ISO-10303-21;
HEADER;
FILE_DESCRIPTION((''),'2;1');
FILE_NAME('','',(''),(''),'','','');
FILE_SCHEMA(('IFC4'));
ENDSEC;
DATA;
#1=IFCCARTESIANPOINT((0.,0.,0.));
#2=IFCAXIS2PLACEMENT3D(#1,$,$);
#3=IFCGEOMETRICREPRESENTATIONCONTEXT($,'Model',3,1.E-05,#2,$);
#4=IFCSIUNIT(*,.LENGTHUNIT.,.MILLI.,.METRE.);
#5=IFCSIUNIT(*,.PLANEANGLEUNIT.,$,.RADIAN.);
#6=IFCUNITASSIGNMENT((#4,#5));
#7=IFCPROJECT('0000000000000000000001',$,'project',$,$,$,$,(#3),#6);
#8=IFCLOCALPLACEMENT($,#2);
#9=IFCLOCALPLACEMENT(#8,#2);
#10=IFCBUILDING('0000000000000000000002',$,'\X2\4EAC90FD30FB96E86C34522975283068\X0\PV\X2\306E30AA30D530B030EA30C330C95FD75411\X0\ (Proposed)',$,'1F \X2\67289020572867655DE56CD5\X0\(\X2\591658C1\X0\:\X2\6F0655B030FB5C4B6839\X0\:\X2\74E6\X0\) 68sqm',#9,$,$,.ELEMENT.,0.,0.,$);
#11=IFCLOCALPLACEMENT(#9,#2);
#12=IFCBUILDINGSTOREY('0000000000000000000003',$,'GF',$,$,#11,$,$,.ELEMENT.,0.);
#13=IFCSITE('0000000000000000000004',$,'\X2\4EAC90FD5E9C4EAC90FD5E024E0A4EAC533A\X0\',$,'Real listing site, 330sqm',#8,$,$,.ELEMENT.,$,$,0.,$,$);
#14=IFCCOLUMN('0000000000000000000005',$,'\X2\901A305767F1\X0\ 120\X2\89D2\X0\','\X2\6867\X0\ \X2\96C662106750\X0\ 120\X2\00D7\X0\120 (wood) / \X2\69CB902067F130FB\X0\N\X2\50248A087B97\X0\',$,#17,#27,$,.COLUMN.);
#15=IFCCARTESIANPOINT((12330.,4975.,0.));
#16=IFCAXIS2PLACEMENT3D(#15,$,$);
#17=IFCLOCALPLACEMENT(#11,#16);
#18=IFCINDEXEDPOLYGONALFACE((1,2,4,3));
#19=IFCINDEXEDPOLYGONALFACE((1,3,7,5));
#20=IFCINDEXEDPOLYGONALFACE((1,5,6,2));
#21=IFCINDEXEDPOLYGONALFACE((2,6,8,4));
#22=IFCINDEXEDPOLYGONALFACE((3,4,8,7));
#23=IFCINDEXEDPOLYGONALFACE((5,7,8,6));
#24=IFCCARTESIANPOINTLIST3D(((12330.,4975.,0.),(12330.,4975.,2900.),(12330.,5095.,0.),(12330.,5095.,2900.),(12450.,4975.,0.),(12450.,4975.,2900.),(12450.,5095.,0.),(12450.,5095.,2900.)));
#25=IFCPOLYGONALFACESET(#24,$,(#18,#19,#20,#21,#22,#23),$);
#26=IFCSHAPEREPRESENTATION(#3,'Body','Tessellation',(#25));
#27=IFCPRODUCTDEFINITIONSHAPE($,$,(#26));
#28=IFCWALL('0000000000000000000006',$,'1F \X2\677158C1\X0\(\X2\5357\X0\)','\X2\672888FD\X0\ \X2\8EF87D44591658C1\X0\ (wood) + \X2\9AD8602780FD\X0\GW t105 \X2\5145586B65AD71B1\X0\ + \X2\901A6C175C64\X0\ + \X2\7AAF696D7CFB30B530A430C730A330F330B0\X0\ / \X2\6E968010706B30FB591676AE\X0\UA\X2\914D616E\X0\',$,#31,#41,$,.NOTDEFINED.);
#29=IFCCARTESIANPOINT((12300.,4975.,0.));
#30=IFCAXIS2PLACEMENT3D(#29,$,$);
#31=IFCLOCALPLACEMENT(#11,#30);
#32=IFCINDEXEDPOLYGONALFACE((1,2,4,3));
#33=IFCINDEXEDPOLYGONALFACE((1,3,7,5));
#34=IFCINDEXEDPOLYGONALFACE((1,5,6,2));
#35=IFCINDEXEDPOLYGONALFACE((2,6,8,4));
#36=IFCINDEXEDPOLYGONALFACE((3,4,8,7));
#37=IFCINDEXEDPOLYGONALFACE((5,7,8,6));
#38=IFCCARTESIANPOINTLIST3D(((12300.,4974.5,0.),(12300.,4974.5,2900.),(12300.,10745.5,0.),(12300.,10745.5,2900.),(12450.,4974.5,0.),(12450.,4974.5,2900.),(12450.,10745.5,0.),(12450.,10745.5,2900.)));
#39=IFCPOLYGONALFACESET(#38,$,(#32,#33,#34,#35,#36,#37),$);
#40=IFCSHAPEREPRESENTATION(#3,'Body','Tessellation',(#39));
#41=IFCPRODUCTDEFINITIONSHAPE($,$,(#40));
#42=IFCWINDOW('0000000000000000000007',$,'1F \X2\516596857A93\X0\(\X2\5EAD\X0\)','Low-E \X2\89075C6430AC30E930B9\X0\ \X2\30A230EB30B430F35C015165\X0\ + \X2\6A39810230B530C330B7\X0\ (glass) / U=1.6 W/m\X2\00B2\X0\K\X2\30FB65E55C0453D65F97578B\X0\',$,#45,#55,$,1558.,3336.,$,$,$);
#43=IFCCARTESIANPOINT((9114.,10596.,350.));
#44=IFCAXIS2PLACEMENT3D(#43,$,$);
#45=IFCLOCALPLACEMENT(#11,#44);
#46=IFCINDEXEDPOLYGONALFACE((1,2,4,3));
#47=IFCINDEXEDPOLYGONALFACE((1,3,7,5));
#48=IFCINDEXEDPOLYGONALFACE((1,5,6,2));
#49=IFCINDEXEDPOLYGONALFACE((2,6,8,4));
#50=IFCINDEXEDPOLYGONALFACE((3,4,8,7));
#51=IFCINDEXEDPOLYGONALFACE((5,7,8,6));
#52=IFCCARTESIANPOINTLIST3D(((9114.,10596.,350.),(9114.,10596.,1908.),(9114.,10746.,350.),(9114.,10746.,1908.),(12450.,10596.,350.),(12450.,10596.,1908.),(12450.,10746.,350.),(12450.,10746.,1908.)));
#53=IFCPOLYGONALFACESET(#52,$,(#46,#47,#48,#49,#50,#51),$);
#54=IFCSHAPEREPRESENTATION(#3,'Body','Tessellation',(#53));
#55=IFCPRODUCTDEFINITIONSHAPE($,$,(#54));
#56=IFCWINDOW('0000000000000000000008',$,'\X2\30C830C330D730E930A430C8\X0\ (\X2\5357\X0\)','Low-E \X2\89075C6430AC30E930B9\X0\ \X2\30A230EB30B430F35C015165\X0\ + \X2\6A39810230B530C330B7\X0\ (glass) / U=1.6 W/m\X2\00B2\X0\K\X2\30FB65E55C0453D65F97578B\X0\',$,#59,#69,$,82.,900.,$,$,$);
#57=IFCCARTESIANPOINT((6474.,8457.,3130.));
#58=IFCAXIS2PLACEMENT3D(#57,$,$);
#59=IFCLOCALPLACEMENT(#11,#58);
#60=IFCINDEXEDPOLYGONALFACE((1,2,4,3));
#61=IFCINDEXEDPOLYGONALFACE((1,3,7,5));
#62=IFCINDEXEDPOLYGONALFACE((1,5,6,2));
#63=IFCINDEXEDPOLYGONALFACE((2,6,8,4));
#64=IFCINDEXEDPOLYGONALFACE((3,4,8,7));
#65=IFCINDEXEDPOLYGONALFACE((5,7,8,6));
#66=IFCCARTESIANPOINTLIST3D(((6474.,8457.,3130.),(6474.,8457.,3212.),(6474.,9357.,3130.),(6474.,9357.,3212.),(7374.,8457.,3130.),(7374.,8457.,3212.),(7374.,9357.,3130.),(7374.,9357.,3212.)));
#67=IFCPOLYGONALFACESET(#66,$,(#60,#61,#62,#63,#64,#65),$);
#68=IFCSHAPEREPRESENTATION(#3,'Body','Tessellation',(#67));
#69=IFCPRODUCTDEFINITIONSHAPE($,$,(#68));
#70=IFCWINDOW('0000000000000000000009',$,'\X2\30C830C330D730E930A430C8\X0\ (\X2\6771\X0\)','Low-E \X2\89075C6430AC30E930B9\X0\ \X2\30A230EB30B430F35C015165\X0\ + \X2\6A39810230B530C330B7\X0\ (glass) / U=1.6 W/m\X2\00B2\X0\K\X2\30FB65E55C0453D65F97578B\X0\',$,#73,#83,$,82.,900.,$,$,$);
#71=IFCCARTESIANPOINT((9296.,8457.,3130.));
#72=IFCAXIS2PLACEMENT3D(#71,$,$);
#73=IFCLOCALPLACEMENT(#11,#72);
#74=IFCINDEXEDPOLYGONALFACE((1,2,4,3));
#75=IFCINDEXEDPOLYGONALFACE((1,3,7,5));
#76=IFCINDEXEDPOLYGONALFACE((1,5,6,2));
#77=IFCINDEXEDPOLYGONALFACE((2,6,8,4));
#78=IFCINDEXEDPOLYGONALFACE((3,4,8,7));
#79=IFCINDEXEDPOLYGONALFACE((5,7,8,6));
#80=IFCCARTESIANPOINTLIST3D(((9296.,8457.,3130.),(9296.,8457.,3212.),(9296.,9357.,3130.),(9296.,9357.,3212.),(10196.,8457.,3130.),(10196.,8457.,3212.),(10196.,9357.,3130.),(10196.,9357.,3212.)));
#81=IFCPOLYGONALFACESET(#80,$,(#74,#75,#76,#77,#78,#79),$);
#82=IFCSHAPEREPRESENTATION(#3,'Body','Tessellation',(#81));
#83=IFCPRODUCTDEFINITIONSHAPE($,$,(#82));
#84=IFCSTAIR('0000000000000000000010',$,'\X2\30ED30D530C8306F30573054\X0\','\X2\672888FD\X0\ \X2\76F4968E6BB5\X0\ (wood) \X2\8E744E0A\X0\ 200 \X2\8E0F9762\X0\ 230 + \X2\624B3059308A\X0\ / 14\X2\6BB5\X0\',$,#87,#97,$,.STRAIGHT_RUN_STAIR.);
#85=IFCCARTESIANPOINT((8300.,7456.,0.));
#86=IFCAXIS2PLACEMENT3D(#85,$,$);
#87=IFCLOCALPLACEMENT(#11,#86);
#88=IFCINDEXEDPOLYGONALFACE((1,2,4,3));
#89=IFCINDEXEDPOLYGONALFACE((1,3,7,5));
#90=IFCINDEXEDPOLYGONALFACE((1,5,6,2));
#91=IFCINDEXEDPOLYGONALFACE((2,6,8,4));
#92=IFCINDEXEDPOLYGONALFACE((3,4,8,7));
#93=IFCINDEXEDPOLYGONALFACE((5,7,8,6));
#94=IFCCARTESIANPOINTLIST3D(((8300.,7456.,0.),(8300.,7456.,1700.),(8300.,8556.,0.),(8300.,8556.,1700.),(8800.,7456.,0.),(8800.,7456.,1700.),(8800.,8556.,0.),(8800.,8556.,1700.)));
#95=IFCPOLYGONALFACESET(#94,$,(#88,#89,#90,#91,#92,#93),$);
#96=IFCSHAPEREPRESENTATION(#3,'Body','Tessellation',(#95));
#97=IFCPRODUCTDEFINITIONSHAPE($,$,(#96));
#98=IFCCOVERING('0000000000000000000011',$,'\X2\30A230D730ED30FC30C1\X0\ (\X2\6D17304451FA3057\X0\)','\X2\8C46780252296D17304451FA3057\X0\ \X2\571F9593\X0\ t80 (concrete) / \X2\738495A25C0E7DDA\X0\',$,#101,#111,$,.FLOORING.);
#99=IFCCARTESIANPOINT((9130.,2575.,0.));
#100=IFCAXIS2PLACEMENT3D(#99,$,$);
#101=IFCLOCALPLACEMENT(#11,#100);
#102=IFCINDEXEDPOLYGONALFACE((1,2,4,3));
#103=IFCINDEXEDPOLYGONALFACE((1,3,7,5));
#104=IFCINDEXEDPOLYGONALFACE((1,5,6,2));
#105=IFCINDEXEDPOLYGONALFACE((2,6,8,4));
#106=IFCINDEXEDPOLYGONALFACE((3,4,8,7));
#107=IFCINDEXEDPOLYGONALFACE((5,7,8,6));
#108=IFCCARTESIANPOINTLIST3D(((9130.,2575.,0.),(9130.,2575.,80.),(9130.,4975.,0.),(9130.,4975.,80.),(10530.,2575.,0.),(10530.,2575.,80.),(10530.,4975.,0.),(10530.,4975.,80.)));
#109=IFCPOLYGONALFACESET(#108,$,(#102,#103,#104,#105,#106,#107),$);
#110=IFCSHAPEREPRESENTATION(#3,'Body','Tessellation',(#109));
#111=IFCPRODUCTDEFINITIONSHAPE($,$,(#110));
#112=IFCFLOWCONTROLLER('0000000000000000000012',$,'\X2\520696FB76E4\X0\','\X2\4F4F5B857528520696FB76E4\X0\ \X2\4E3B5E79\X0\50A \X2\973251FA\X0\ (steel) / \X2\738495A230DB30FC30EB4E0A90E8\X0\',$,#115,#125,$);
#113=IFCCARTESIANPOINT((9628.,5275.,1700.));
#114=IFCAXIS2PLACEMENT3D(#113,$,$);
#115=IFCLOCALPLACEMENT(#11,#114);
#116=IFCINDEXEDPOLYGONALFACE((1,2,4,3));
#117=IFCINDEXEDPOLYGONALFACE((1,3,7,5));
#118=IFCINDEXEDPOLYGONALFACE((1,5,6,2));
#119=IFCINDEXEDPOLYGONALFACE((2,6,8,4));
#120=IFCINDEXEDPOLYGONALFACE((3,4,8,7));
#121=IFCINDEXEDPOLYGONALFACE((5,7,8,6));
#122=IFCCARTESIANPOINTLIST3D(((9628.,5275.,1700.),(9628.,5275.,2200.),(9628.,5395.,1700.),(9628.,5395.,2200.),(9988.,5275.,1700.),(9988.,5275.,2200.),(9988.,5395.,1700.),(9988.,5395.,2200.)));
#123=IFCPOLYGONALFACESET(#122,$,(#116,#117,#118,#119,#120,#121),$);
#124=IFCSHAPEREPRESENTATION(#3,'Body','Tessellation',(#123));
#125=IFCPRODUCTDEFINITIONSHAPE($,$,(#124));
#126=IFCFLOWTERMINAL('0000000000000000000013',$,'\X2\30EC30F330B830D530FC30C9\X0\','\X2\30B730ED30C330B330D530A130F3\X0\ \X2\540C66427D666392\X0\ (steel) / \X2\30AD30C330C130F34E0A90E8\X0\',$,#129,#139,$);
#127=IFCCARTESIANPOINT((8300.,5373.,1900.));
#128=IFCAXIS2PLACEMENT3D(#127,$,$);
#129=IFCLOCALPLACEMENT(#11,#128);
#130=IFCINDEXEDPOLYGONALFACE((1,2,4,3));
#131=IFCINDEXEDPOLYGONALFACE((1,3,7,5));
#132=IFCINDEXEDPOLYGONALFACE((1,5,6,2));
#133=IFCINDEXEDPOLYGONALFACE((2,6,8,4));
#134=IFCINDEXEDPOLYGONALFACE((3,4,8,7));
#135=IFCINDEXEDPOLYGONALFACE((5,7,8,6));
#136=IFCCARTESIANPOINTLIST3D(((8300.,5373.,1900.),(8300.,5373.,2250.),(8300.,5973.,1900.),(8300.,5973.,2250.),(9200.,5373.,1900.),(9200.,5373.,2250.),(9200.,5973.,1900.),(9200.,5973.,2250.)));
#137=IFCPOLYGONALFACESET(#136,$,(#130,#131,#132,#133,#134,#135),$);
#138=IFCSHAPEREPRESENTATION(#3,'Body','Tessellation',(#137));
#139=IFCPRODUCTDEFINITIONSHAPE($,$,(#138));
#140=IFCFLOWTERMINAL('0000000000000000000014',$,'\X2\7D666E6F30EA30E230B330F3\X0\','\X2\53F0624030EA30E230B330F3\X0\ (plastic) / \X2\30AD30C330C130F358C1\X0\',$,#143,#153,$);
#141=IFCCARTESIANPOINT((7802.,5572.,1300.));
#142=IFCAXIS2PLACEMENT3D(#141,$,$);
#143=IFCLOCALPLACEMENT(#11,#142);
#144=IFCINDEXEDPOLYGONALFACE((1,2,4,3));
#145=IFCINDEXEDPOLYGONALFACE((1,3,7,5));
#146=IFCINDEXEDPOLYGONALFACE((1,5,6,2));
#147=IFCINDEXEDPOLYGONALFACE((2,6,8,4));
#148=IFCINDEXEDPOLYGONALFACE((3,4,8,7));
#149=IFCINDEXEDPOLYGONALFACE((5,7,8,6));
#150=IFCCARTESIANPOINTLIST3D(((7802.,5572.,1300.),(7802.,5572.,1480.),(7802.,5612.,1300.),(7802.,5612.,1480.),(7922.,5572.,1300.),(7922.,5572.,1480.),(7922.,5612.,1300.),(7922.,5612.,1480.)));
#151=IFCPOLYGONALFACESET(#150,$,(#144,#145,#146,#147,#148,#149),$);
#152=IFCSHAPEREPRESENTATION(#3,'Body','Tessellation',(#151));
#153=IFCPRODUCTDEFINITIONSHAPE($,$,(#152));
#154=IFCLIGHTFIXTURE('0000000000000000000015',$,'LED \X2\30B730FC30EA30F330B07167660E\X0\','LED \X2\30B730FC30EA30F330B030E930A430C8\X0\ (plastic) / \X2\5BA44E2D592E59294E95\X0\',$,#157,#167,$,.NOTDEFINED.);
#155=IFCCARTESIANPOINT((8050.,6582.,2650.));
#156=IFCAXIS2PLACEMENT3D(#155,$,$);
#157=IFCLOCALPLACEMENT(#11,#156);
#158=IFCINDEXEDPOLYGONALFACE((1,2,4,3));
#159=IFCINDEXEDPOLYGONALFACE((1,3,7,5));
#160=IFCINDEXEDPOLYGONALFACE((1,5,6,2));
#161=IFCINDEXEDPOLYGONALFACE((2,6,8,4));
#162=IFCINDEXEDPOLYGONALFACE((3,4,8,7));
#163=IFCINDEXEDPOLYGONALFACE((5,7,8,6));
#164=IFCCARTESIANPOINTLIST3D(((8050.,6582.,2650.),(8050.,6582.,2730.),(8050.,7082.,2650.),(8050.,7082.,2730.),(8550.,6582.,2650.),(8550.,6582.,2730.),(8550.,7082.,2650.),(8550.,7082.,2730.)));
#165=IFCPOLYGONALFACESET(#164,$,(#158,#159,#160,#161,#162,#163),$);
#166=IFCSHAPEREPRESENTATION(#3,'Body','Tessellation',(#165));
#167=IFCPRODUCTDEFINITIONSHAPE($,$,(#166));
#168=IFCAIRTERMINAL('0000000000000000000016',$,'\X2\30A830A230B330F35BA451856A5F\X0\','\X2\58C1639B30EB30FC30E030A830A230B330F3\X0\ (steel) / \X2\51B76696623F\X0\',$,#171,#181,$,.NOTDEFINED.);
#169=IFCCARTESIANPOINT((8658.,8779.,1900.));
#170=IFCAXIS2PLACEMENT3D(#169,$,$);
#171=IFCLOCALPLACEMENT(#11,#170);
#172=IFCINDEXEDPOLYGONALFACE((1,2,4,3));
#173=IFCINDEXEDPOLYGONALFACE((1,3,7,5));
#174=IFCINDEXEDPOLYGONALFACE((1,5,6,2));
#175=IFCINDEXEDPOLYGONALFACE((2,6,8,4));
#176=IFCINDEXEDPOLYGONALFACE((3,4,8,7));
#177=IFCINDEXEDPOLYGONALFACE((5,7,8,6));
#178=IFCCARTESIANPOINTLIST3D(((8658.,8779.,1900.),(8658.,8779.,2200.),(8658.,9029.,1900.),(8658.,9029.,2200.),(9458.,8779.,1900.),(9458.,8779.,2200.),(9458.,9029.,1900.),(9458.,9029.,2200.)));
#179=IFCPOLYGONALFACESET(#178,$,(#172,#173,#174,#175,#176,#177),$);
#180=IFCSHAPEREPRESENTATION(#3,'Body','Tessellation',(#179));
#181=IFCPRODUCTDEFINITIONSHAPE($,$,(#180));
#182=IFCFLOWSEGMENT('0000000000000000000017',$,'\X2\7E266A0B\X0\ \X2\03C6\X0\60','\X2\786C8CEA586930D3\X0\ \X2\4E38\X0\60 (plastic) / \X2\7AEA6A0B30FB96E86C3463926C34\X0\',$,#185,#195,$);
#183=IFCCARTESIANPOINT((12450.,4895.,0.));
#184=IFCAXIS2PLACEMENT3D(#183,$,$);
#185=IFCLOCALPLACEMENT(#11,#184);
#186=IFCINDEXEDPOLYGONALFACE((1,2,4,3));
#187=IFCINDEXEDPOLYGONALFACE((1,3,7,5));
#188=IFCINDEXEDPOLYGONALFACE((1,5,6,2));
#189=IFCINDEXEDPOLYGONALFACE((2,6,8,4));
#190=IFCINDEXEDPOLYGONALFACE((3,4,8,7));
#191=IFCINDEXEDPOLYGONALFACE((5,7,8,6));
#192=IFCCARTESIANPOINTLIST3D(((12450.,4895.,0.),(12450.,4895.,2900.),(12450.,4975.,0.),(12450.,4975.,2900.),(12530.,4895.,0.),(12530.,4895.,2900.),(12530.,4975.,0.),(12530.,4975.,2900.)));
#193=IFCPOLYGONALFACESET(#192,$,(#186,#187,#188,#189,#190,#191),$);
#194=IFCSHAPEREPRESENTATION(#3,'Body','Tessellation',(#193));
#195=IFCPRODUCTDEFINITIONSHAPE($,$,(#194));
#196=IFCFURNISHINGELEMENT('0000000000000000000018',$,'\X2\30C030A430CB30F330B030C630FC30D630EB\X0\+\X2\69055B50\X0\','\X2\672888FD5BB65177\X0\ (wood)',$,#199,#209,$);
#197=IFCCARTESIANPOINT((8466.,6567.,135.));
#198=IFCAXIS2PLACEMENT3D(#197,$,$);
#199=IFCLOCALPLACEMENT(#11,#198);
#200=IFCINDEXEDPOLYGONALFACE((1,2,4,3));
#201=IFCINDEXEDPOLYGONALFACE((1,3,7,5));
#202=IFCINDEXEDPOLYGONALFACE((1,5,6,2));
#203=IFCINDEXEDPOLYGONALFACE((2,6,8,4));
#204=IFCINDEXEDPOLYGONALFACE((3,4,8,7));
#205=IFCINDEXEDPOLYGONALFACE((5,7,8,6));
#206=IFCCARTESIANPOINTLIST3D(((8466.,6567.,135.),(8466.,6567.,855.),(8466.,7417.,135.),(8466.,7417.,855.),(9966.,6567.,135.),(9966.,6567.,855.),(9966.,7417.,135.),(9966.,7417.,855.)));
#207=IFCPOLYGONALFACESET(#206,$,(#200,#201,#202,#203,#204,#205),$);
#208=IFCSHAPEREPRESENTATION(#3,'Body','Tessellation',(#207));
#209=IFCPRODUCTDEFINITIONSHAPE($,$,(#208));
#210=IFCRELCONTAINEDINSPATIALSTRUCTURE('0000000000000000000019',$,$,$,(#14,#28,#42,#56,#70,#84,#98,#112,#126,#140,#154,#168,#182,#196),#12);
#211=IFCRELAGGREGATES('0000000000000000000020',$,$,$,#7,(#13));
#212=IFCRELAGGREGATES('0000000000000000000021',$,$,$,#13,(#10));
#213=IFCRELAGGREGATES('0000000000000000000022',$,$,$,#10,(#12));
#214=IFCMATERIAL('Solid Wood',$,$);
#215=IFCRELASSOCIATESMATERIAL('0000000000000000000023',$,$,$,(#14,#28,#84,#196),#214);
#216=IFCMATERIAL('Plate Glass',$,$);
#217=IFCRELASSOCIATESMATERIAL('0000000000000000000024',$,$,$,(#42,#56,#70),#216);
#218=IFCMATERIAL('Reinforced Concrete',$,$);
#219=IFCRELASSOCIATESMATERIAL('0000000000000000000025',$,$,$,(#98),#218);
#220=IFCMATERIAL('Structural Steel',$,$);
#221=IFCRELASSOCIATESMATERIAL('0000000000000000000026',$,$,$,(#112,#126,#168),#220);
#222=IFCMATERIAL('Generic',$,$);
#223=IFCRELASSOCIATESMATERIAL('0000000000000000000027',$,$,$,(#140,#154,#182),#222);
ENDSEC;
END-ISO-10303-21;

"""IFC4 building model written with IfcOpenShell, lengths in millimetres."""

from ifc_helpers import new_model, si_unit, frame, frame_2d, origin, place, context, project, spatial, rectangle, extrude, material, element, fill, save


model = new_model("IFC4")

# Units and contexts
model_context = context("Model", 3, precision=1e-05, world=origin())
ifc_project = project(units=[si_unit("LENGTHUNIT", "METRE", prefix="MILLI"), si_unit("PLANEANGLEUNIT", "RADIAN")], contexts=[model_context])

# Site, building, storey
site_placement = place(None, origin())
site = spatial("IfcSite", under=ifc_project, at=site_placement, Name="京都府京都市上京区", ObjectType="Real listing site, 330sqm", CompositionType="ELEMENT", RefElevation=0.0)
building_placement = place(site_placement, origin())
building = spatial("IfcBuilding", under=site, at=building_placement, Name="京都・雨水利用とPVのオフグリッド志向 (Proposed)", ObjectType="1F 木造在来工法(外壁:漆喰・屋根:瓦) 68sqm", CompositionType="ELEMENT", ElevationOfRefHeight=0.0, ElevationOfTerrain=0.0)
storey_placement = place(building_placement, origin())
storey = spatial("IfcBuildingStorey", under=building, at=storey_placement, Name="GF", CompositionType="ELEMENT", Elevation=0.0)

# Column
ifc_material_1 = material(Name="Solid Wood")
column_1_placement = place(storey_placement, frame((12330.0, 4975.0, 0.0)))
element("IfcColumn", 1, at=column_1_placement, inside=storey, material=ifc_material_1, Name="通し柱 120角", Description="桧 集成材 120×120 (wood) / 構造柱・N値計算", PredefinedType="COLUMN", context=model_context, shape_type="SweptSolid", body=[
    extrude(rectangle(XDim=120.0, YDim=120.0, at=frame_2d((60.0, 60.0))), frame((12330.0, 4975.0, 0.0)), (0.0, 0.0, 1.0), 2900.0),
])

# Wall, opening, window
wall_1_placement = place(storey_placement, frame((12300.0, 4975.0, 0.0)))
wall_1 = element("IfcWall", 2, at=wall_1_placement, inside=storey, material=ifc_material_1, Name="1F 東壁(南)", Description="木製 軸組外壁 (wood) + 高性能GW t105 充填断熱 + 通気層 + 窯業系サイディング / 準耐火・外皮UA配慮", PredefinedType="NOTDEFINED", context=model_context, shape_type="SweptSolid", body=[
    extrude(rectangle(XDim=150.0, YDim=5771.0, at=frame_2d((75.0, 2885.0))), frame((12300.0, 4975.0, 0.0)), (0.0, 0.0, 1.0), 2900.0),
])
opening_1_placement = place(storey_placement, frame((9114.0, 10596.0, 350.0)))
opening_1 = element("IfcOpeningElement", 3, at=opening_1_placement, cuts=wall_1, PredefinedType="NOTDEFINED", context=model_context, shape_type="SweptSolid", body=[
    extrude(rectangle(XDim=3336.0, YDim=150.0, at=frame_2d((1668.0, 75.0))), frame((9114.0, 10596.0, 350.0)), (0.0, 0.0, 1.0), 1558.0),
])
ifc_material_2 = material(Name="Plate Glass")
window_1_placement = place(storey_placement, frame((9114.0, 10596.0, 350.0)))
window_1 = element("IfcWindow", 4, at=window_1_placement, inside=storey, material=ifc_material_2, Name="1F 入隅窓(庭)", Description="Low-E 複層ガラス アルゴン封入 + 樹脂サッシ (glass) / U=1.6 W/m²K・日射取得型", OverallHeight=1558.0, OverallWidth=3336.0, context=model_context, shape_type="SweptSolid", body=[
    extrude(rectangle(XDim=3336.0, YDim=150.0, at=frame_2d((1668.0, 75.0))), frame((9114.0, 10596.0, 350.0)), (0.0, 0.0, 1.0), 1558.0),
])
fill(opening_1, window_1)

# Windows
window_2_placement = place(storey_placement, frame((6474.0, 8457.0, 3130.0)))
element("IfcWindow", 5, at=window_2_placement, inside=storey, material=ifc_material_2, Name="トップライト (南)", Description="Low-E 複層ガラス アルゴン封入 + 樹脂サッシ (glass) / U=1.6 W/m²K・日射取得型", OverallHeight=82.0, OverallWidth=900.0, context=model_context, shape_type="SweptSolid", body=[
    extrude(rectangle(XDim=900.0, YDim=900.0, at=frame_2d((450.0, 450.0))), frame((6474.0, 8457.0, 3130.0)), (0.0, 0.0, 1.0), 82.0),
])
window_3_placement = place(storey_placement, frame((9296.0, 8457.0, 3130.0)))
element("IfcWindow", 6, at=window_3_placement, inside=storey, material=ifc_material_2, Name="トップライト (東)", Description="Low-E 複層ガラス アルゴン封入 + 樹脂サッシ (glass) / U=1.6 W/m²K・日射取得型", OverallHeight=82.0, OverallWidth=900.0, context=model_context, shape_type="SweptSolid", body=[
    extrude(rectangle(XDim=900.0, YDim=900.0, at=frame_2d((450.0, 450.0))), frame((9296.0, 8457.0, 3130.0)), (0.0, 0.0, 1.0), 82.0),
])

# Stair
stair_placement = place(storey_placement, frame((8300.0, 7456.0, 0.0)))
element("IfcStair", 7, at=stair_placement, inside=storey, material=ifc_material_1, Name="ロフトはしご", Description="木製 直階段 (wood) 蹴上 200 踏面 230 + 手すり / 14段", PredefinedType="STRAIGHT_RUN_STAIR", context=model_context, shape_type="SweptSolid", body=[
    extrude(rectangle(XDim=500.0, YDim=1100.0, at=frame_2d((250.0, 550.0))), frame((8300.0, 7456.0, 0.0)), (0.0, 0.0, 1.0), 1700.0),
])

# Covering
ifc_material_3 = material(Name="Reinforced Concrete")
covering_placement = place(storey_placement, frame((9130.0, 2575.0, 0.0)))
element("IfcCovering", 8, at=covering_placement, inside=storey, material=ifc_material_3, Name="アプローチ (洗い出し)", Description="豆砂利洗い出し 土間 t80 (concrete) / 玄関導線", PredefinedType="FLOORING", context=model_context, shape_type="SweptSolid", body=[
    extrude(rectangle(XDim=1400.0, YDim=2400.0, at=frame_2d((700.0, 1200.0))), frame((9130.0, 2575.0, 0.0)), (0.0, 0.0, 1.0), 80.0),
])

# Flow controller
ifc_material_4 = material(Name="Structural Steel")
flow_controller_placement = place(storey_placement, frame((9628.0, 5275.0, 1700.0)))
element("IfcFlowController", 9, at=flow_controller_placement, inside=storey, material=ifc_material_4, Name="分電盤", Description="住宅用分電盤 主幹50A 露出 (steel) / 玄関ホール上部", context=model_context, shape_type="SweptSolid", body=[
    extrude(rectangle(XDim=360.0, YDim=120.0, at=frame_2d((180.0, 60.0))), frame((9628.0, 5275.0, 1700.0)), (0.0, 0.0, 1.0), 500.0),
])

# Flow terminals
flow_terminal_1_placement = place(storey_placement, frame((8300.0, 5373.0, 1900.0)))
element("IfcFlowTerminal", 10, at=flow_terminal_1_placement, inside=storey, material=ifc_material_4, Name="レンジフード", Description="シロッコファン 同時給排 (steel) / キッチン上部", context=model_context, shape_type="SweptSolid", body=[
    extrude(rectangle(XDim=900.0, YDim=600.0, at=frame_2d((450.0, 300.0))), frame((8300.0, 5373.0, 1900.0)), (0.0, 0.0, 1.0), 350.0),
])
ifc_material_5 = material(Name="Generic")
flow_terminal_2_placement = place(storey_placement, frame((7802.0, 5572.0, 1300.0)))
element("IfcFlowTerminal", 11, at=flow_terminal_2_placement, inside=storey, material=ifc_material_5, Name="給湯リモコン", Description="台所リモコン (plastic) / キッチン壁", context=model_context, shape_type="SweptSolid", body=[
    extrude(rectangle(XDim=120.0, YDim=40.0, at=frame_2d((60.0, 20.0))), frame((7802.0, 5572.0, 1300.0)), (0.0, 0.0, 1.0), 180.0),
])

# Light fixture
light_fixture_placement = place(storey_placement, frame((8050.0, 6582.0, 2650.0)))
element("IfcLightFixture", 12, at=light_fixture_placement, inside=storey, material=ifc_material_5, Name="LED シーリング照明", Description="LED シーリングライト (plastic) / 室中央天井", PredefinedType="NOTDEFINED", context=model_context, shape_type="SweptSolid", body=[
    extrude(rectangle(XDim=500.0, YDim=500.0, at=frame_2d((250.0, 250.0))), frame((8050.0, 6582.0, 2650.0)), (0.0, 0.0, 1.0), 80.0),
])

# Air terminal
air_terminal_placement = place(storey_placement, frame((8658.0, 8779.0, 1900.0)))
element("IfcAirTerminal", 13, at=air_terminal_placement, inside=storey, material=ifc_material_4, Name="エアコン室内機", Description="壁掛ルームエアコン (steel) / 冷暖房", PredefinedType="NOTDEFINED", context=model_context, shape_type="SweptSolid", body=[
    extrude(rectangle(XDim=800.0, YDim=250.0, at=frame_2d((400.0, 125.0))), frame((8658.0, 8779.0, 1900.0)), (0.0, 0.0, 1.0), 300.0),
])

# Flow segment
flow_segment_placement = place(storey_placement, frame((12450.0, 4895.0, 0.0)))
element("IfcFlowSegment", 14, at=flow_segment_placement, inside=storey, material=ifc_material_5, Name="縦樋 φ60", Description="硬質塩ビ 丸60 (plastic) / 竪樋・雨水排水", context=model_context, shape_type="SweptSolid", body=[
    extrude(rectangle(XDim=80.0, YDim=80.0, at=frame_2d((40.0, 40.0))), frame((12450.0, 4895.0, 0.0)), (0.0, 0.0, 1.0), 2900.0),
])

# Furnishing element
furnishing_1_placement = place(storey_placement, frame((8466.0, 6567.0, 135.0)))
element("IfcFurnishingElement", 15, at=furnishing_1_placement, inside=storey, material=ifc_material_1, Name="ダイニングテーブル+椅子", Description="木製家具 (wood)", context=model_context, shape_type="SweptSolid", body=[
    extrude(rectangle(XDim=1500.0, YDim=850.0, at=frame_2d((750.0, 425.0))), frame((8466.0, 6567.0, 135.0)), (0.0, 0.0, 1.0), 720.0),
])

save(model, "model.ifc")
